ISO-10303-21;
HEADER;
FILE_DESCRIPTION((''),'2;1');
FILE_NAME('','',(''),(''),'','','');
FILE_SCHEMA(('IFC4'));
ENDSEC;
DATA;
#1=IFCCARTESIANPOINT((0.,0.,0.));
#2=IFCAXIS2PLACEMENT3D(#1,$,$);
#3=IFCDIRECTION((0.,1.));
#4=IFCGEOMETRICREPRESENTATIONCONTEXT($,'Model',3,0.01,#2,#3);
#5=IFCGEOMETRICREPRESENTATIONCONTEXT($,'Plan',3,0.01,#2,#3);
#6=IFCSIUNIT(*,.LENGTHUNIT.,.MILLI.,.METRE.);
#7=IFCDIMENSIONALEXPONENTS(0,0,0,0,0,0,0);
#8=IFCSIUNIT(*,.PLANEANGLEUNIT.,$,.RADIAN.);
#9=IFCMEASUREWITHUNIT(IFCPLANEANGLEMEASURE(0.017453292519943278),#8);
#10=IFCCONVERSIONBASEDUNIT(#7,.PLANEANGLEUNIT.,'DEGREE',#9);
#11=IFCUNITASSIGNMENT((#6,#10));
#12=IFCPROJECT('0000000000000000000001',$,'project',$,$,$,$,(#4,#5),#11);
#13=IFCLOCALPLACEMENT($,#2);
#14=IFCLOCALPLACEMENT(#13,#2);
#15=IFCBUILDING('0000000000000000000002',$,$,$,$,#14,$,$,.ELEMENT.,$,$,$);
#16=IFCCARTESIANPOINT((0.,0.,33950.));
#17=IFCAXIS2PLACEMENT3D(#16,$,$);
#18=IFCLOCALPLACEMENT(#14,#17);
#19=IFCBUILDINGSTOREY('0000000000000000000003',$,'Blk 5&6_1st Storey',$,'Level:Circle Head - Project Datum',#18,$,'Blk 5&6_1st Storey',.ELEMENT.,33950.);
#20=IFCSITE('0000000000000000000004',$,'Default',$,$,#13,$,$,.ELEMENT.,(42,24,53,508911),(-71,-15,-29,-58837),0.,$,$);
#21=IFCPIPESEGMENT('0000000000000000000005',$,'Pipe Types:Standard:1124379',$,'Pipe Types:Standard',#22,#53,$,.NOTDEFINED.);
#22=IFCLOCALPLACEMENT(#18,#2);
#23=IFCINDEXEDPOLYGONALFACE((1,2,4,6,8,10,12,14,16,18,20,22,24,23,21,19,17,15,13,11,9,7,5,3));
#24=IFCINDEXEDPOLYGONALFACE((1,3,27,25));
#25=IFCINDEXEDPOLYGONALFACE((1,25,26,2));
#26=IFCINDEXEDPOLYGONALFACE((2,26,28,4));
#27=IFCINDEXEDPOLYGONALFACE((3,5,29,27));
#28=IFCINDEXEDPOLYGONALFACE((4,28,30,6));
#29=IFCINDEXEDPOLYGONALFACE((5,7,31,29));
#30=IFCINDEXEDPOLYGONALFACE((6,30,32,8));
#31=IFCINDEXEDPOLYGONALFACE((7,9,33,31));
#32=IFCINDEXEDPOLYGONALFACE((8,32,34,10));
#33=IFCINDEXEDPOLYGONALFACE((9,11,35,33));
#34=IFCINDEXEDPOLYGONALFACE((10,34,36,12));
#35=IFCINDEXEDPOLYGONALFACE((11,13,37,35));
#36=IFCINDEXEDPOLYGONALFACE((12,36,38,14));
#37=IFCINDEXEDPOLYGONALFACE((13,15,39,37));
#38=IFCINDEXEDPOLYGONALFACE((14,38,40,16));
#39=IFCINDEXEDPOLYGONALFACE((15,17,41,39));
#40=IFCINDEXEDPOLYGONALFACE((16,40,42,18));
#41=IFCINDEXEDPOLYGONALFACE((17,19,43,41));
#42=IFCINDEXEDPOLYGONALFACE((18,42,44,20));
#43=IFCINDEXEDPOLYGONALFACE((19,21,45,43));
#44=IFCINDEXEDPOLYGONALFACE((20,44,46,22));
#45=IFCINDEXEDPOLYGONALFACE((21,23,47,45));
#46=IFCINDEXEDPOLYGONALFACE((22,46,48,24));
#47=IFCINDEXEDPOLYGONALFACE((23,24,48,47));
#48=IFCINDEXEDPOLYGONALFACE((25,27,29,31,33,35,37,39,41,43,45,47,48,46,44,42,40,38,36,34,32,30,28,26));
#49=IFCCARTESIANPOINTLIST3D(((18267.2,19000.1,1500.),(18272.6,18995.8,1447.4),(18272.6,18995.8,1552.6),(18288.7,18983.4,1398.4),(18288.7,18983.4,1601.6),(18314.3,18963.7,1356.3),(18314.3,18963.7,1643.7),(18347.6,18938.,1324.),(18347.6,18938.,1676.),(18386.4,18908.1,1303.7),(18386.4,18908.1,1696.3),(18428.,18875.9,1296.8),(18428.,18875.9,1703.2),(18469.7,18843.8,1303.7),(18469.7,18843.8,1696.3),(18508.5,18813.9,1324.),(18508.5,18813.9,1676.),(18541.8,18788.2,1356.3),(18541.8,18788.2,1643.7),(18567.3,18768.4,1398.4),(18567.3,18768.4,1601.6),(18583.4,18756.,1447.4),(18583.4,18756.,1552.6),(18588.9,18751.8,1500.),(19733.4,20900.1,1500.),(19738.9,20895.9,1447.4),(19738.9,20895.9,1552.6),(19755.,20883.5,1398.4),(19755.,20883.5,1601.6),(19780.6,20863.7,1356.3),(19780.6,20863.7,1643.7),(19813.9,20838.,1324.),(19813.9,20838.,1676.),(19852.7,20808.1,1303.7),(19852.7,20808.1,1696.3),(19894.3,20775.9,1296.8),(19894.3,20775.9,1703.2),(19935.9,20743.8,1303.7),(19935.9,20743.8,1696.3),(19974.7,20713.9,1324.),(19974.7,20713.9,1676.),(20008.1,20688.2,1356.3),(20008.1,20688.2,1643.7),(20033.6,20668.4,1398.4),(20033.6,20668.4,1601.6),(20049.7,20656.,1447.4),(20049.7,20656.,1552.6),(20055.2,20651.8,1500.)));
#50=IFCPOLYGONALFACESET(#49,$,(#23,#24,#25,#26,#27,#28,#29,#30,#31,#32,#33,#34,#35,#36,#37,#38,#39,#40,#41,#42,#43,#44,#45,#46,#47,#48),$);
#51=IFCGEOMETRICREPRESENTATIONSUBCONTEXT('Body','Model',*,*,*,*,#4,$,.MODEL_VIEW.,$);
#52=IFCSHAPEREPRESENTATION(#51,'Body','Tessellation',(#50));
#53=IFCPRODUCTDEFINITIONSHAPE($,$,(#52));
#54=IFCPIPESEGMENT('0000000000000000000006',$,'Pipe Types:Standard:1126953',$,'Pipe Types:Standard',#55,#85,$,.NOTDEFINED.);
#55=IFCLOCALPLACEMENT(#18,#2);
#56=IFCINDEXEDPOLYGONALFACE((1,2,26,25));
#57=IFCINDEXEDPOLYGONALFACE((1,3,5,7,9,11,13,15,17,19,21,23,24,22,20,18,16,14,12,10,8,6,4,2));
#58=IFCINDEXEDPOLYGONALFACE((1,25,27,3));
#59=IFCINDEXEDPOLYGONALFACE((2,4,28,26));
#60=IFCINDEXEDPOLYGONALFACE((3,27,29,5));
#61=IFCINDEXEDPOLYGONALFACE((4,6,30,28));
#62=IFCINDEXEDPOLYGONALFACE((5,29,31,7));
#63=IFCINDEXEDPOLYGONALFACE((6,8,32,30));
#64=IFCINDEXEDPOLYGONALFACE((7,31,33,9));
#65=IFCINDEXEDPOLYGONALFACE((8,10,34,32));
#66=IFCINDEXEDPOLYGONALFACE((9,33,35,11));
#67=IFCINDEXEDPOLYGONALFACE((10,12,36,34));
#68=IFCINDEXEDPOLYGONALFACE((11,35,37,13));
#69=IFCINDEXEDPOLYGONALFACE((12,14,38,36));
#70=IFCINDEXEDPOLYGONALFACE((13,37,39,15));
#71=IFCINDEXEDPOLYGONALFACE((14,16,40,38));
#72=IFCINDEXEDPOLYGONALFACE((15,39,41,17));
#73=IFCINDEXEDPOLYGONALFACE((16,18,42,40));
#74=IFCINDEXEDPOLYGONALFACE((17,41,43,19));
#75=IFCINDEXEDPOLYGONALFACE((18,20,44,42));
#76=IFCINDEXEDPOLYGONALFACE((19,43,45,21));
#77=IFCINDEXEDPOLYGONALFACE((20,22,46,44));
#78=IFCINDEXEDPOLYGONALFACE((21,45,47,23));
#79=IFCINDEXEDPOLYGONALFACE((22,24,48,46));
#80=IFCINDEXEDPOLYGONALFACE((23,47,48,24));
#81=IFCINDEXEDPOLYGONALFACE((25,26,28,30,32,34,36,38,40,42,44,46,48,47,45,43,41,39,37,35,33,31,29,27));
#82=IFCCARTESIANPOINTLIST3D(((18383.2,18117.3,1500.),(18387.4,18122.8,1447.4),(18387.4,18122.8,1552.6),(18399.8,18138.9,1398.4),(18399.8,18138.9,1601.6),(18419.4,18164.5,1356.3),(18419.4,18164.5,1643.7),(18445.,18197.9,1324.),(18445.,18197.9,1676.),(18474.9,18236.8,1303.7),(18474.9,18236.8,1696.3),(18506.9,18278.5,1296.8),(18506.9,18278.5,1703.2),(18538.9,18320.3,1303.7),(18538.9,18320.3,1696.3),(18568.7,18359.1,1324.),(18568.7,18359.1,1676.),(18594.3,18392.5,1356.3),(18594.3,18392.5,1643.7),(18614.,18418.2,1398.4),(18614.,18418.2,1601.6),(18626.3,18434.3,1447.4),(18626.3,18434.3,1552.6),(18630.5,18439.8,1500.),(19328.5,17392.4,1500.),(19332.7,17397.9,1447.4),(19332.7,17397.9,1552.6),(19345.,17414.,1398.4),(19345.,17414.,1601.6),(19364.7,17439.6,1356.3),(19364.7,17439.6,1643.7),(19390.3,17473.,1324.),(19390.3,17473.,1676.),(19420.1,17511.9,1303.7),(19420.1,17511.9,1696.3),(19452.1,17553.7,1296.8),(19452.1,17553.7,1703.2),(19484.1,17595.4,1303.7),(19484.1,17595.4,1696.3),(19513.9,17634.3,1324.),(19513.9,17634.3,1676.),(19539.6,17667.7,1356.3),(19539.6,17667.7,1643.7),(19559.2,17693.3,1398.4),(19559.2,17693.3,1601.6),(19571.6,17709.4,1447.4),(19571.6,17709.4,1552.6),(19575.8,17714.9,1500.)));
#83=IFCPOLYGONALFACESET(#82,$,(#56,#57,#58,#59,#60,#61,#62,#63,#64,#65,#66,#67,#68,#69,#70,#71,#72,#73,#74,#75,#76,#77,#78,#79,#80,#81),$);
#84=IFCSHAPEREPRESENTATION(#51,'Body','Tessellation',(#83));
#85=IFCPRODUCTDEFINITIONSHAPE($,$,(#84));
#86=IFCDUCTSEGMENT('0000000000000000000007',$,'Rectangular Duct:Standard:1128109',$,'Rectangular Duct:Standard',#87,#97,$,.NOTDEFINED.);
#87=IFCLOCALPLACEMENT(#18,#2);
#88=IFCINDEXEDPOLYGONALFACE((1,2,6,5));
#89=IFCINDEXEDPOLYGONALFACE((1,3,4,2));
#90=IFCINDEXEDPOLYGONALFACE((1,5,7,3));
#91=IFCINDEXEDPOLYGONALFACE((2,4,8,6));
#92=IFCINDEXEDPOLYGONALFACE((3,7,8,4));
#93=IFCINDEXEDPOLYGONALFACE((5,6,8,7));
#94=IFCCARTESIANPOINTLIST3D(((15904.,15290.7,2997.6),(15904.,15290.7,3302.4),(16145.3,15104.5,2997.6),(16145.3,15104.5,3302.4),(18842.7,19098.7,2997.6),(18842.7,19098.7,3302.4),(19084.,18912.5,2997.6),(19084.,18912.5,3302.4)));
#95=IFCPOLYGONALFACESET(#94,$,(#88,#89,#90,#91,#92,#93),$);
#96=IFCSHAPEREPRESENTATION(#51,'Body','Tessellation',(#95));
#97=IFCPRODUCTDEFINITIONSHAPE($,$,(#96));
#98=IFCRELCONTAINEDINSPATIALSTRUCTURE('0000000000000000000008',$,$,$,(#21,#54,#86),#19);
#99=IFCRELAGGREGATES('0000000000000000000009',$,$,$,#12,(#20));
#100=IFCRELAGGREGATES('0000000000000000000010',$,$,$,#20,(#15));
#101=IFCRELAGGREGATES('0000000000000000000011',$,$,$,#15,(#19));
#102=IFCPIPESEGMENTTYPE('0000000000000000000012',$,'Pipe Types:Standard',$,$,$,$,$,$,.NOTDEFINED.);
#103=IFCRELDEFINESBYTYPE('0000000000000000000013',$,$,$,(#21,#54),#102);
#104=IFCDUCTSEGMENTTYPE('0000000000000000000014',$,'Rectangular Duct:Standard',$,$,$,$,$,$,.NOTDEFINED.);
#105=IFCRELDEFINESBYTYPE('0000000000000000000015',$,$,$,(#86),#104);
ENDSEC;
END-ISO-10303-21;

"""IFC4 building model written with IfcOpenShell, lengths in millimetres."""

from ifc_helpers import new_model, entity, si_unit, converted_unit, direction, frame, origin, place, context, subcontext, project, spatial, arc, indexed_curve, outline, extrude, type_object, element, save


model = new_model("IFC4")

# Units and contexts
model_context = context("Model", 3, precision=0.01, world=origin(), true_north=direction((0.0, 1.0)))
plan_context = context("Plan", 3, precision=0.01, world=origin(), true_north=direction((0.0, 1.0)))
body_context = subcontext(model_context, "Body", "Model", "MODEL_VIEW")
ifc_project = project(units=[si_unit("LENGTHUNIT", "METRE", prefix="MILLI"), converted_unit("PLANEANGLEUNIT", "DEGREE", entity("IfcPlaneAngleMeasure", 0.017453292519943278), si_unit("PLANEANGLEUNIT", "RADIAN"), dimensions=[0, 0, 0, 0, 0, 0, 0])], contexts=[model_context, plan_context])

# Site, building, storey
site_placement = place(None, origin())
site = spatial("IfcSite", under=ifc_project, at=site_placement, Name="Default", CompositionType="ELEMENT", RefLatitude=(42, 24, 53, 508911), RefLongitude=(-71, -15, -29, -58837), RefElevation=0.0)
building_placement = place(site_placement, origin())
building = spatial("IfcBuilding", under=site, at=building_placement, CompositionType="ELEMENT")
storey_placement = place(building_placement, frame((0.0, 0.0, 33950.0)))
storey = spatial("IfcBuildingStorey", under=building, at=storey_placement, Name="Blk 5&6_1st Storey", ObjectType="Level:Circle Head - Project Datum", LongName="Blk 5&6_1st Storey", CompositionType="ELEMENT", Elevation=33950.0)

# Pipe segments
pipe_segment_type = type_object("IfcPipeSegmentType", Name="Pipe Types:Standard", PredefinedType="NOTDEFINED")
pipe_segment_1_placement = place(storey_placement, origin())
element("IfcPipeSegment", 1, at=pipe_segment_1_placement, inside=storey, type_object=pipe_segment_type, Name="Pipe Types:Standard:1124379", ObjectType="Pipe Types:Standard", PredefinedType="NOTDEFINED", context=body_context, shape_type="SweptSolid", body=[
    extrude(outline(indexed_curve([(203.2, 0.0), (143.7, 143.7), (0.0, 203.2), (-143.7, 143.7), (-203.2, 0.0), (-143.7, -143.7), (0.0, -203.2), (143.7, -143.7)], segments=[arc(1, 2, 3), arc(3, 4, 5), arc(5, 6, 7), arc(7, 8, 1)], self_intersect=False)), frame((18428.0, 18875.9, 1500.0), z_axis=(0.61095, 0.79167, 0.0), x_axis=(-0.79167, 0.61095, 0.0)), (0.0, 0.0, 1.0), 2400.0),
])
pipe_segment_2_placement = place(storey_placement, origin())
element("IfcPipeSegment", 2, at=pipe_segment_2_placement, inside=storey, type_object=pipe_segment_type, Name="Pipe Types:Standard:1126953", ObjectType="Pipe Types:Standard", PredefinedType="NOTDEFINED", context=body_context, shape_type="SweptSolid", body=[
    extrude(outline(indexed_curve([(203.2, 0.0), (143.7, 143.7), (0.0, 203.2), (-143.7, 143.7), (-203.2, 0.0), (-143.7, -143.7), (0.0, -203.2), (143.7, -143.7)], segments=[arc(1, 2, 3), arc(3, 4, 5), arc(5, 6, 7), arc(7, 8, 1)], self_intersect=False)), frame((18506.9, 18278.5, 1500.0), z_axis=(0.793539, -0.60852, 0.0), x_axis=(0.60852, 0.793539, 0.0)), (0.0, 0.0, 1.0), 1191.2),
])

# Duct segment
duct_segment_type = type_object("IfcDuctSegmentType", Name="Rectangular Duct:Standard", PredefinedType="NOTDEFINED")
duct_segment_placement = place(storey_placement, origin())
element("IfcDuctSegment", 3, at=duct_segment_placement, inside=storey, type_object=duct_segment_type, Name="Rectangular Duct:Standard:1128109", ObjectType="Rectangular Duct:Standard", PredefinedType="NOTDEFINED", context=body_context, shape_type="SweptSolid", body=[
    extrude(outline(indexed_curve([(-2405.0, -152.4), (2405.0, -152.4), (2405.0, 152.4), (-2405.0, 152.4), (-2405.0, -152.4)], self_intersect=False)), frame((17494.0, 17101.6, 2997.6), z_axis=(0.0, 0.0, 1.0), x_axis=(0.610948, 0.79167, 0.0)), (0.0, 0.0, 1.0), 304.8),
])

save(model, "model.ifc")
